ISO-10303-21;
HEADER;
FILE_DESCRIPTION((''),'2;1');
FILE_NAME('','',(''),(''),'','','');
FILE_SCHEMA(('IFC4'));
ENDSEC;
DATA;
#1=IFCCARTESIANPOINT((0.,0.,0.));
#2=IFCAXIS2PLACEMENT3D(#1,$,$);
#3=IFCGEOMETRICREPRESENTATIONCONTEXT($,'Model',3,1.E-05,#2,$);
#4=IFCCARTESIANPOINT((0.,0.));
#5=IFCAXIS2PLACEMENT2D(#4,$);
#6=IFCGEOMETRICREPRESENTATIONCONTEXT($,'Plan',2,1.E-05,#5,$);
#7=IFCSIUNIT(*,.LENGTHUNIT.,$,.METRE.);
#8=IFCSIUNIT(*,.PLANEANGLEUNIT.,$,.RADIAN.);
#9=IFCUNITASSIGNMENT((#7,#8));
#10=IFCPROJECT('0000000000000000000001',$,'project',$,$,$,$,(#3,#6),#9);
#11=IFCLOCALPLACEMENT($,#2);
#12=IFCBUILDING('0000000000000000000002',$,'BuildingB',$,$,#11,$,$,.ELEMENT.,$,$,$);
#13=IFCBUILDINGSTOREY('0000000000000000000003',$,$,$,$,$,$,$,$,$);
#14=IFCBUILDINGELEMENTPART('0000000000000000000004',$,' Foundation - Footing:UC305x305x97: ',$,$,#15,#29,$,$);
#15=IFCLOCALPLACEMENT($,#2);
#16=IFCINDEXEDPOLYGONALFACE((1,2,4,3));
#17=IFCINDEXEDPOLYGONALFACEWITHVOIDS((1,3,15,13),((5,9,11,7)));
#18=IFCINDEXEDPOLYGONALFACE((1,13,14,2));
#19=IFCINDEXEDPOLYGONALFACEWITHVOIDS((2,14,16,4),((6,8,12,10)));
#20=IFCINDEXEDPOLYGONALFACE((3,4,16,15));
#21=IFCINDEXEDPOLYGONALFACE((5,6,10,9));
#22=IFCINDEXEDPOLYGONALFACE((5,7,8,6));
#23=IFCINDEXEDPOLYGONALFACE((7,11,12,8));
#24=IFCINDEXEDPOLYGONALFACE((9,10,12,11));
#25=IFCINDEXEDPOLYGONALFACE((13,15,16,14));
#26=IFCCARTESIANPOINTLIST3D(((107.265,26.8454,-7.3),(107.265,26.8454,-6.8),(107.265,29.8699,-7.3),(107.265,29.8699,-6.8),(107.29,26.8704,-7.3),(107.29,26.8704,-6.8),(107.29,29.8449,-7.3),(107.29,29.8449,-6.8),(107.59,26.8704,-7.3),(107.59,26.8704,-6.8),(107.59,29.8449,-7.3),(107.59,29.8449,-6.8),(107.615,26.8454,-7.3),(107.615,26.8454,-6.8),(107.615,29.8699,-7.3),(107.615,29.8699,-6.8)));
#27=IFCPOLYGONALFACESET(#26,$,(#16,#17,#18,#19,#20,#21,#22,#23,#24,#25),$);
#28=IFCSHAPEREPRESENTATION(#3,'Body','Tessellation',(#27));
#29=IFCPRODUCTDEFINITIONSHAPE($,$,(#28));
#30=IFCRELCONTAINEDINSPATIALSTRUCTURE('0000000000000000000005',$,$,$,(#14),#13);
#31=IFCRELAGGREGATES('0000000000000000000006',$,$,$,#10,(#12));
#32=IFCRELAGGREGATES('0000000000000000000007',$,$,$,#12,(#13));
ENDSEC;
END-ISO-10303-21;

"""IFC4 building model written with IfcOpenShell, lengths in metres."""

from ifc_helpers import new_model, si_unit, origin, origin_2d, place, context, project, spatial, polyline, outline, extrude, element, save


model = new_model("IFC4")

# Units and contexts
model_context = context("Model", 3, precision=1e-05, world=origin())
plan_context = context("Plan", 2, precision=1e-05, world=origin_2d())
ifc_project = project(units=[si_unit("LENGTHUNIT", "METRE"), si_unit("PLANEANGLEUNIT", "RADIAN")], contexts=[model_context, plan_context])

# Building, storey
building_placement = place(None, origin())
building = spatial("IfcBuilding", under=ifc_project, at=building_placement, Name="BuildingB", CompositionType="ELEMENT")
storey = spatial("IfcBuildingStorey", under=building)

# Building element part, opening
building_element_part_1 = element("IfcBuildingElementPart", 1, inside=storey, Name=" Foundation - Footing:UC305x305x97: ", context=model_context, shape_type="SweptSolid", body=[
    extrude(outline(polyline([(107.265, 26.8454, -7.3), (107.615, 26.8454, -7.3), (107.615, 29.8699, -7.3), (107.265, 29.8699, -7.3), (107.265, 26.8454, -7.3)])), None, (0.0, 0.0, 1.0), 0.5),
])
element("IfcOpeningElement", 2, inside=storey, cuts=building_element_part_1, context=model_context, shape_type="SweptSolid", body=[
    extrude(outline(polyline([(107.29, 26.8704, -7.3), (107.59, 26.8704, -7.3), (107.59, 29.8449, -7.3), (107.29, 29.8449, -7.3), (107.29, 26.8704, -7.3)])), None, (0.0, 0.0, 1.0), 0.5),
])

save(model, "model.ifc")
